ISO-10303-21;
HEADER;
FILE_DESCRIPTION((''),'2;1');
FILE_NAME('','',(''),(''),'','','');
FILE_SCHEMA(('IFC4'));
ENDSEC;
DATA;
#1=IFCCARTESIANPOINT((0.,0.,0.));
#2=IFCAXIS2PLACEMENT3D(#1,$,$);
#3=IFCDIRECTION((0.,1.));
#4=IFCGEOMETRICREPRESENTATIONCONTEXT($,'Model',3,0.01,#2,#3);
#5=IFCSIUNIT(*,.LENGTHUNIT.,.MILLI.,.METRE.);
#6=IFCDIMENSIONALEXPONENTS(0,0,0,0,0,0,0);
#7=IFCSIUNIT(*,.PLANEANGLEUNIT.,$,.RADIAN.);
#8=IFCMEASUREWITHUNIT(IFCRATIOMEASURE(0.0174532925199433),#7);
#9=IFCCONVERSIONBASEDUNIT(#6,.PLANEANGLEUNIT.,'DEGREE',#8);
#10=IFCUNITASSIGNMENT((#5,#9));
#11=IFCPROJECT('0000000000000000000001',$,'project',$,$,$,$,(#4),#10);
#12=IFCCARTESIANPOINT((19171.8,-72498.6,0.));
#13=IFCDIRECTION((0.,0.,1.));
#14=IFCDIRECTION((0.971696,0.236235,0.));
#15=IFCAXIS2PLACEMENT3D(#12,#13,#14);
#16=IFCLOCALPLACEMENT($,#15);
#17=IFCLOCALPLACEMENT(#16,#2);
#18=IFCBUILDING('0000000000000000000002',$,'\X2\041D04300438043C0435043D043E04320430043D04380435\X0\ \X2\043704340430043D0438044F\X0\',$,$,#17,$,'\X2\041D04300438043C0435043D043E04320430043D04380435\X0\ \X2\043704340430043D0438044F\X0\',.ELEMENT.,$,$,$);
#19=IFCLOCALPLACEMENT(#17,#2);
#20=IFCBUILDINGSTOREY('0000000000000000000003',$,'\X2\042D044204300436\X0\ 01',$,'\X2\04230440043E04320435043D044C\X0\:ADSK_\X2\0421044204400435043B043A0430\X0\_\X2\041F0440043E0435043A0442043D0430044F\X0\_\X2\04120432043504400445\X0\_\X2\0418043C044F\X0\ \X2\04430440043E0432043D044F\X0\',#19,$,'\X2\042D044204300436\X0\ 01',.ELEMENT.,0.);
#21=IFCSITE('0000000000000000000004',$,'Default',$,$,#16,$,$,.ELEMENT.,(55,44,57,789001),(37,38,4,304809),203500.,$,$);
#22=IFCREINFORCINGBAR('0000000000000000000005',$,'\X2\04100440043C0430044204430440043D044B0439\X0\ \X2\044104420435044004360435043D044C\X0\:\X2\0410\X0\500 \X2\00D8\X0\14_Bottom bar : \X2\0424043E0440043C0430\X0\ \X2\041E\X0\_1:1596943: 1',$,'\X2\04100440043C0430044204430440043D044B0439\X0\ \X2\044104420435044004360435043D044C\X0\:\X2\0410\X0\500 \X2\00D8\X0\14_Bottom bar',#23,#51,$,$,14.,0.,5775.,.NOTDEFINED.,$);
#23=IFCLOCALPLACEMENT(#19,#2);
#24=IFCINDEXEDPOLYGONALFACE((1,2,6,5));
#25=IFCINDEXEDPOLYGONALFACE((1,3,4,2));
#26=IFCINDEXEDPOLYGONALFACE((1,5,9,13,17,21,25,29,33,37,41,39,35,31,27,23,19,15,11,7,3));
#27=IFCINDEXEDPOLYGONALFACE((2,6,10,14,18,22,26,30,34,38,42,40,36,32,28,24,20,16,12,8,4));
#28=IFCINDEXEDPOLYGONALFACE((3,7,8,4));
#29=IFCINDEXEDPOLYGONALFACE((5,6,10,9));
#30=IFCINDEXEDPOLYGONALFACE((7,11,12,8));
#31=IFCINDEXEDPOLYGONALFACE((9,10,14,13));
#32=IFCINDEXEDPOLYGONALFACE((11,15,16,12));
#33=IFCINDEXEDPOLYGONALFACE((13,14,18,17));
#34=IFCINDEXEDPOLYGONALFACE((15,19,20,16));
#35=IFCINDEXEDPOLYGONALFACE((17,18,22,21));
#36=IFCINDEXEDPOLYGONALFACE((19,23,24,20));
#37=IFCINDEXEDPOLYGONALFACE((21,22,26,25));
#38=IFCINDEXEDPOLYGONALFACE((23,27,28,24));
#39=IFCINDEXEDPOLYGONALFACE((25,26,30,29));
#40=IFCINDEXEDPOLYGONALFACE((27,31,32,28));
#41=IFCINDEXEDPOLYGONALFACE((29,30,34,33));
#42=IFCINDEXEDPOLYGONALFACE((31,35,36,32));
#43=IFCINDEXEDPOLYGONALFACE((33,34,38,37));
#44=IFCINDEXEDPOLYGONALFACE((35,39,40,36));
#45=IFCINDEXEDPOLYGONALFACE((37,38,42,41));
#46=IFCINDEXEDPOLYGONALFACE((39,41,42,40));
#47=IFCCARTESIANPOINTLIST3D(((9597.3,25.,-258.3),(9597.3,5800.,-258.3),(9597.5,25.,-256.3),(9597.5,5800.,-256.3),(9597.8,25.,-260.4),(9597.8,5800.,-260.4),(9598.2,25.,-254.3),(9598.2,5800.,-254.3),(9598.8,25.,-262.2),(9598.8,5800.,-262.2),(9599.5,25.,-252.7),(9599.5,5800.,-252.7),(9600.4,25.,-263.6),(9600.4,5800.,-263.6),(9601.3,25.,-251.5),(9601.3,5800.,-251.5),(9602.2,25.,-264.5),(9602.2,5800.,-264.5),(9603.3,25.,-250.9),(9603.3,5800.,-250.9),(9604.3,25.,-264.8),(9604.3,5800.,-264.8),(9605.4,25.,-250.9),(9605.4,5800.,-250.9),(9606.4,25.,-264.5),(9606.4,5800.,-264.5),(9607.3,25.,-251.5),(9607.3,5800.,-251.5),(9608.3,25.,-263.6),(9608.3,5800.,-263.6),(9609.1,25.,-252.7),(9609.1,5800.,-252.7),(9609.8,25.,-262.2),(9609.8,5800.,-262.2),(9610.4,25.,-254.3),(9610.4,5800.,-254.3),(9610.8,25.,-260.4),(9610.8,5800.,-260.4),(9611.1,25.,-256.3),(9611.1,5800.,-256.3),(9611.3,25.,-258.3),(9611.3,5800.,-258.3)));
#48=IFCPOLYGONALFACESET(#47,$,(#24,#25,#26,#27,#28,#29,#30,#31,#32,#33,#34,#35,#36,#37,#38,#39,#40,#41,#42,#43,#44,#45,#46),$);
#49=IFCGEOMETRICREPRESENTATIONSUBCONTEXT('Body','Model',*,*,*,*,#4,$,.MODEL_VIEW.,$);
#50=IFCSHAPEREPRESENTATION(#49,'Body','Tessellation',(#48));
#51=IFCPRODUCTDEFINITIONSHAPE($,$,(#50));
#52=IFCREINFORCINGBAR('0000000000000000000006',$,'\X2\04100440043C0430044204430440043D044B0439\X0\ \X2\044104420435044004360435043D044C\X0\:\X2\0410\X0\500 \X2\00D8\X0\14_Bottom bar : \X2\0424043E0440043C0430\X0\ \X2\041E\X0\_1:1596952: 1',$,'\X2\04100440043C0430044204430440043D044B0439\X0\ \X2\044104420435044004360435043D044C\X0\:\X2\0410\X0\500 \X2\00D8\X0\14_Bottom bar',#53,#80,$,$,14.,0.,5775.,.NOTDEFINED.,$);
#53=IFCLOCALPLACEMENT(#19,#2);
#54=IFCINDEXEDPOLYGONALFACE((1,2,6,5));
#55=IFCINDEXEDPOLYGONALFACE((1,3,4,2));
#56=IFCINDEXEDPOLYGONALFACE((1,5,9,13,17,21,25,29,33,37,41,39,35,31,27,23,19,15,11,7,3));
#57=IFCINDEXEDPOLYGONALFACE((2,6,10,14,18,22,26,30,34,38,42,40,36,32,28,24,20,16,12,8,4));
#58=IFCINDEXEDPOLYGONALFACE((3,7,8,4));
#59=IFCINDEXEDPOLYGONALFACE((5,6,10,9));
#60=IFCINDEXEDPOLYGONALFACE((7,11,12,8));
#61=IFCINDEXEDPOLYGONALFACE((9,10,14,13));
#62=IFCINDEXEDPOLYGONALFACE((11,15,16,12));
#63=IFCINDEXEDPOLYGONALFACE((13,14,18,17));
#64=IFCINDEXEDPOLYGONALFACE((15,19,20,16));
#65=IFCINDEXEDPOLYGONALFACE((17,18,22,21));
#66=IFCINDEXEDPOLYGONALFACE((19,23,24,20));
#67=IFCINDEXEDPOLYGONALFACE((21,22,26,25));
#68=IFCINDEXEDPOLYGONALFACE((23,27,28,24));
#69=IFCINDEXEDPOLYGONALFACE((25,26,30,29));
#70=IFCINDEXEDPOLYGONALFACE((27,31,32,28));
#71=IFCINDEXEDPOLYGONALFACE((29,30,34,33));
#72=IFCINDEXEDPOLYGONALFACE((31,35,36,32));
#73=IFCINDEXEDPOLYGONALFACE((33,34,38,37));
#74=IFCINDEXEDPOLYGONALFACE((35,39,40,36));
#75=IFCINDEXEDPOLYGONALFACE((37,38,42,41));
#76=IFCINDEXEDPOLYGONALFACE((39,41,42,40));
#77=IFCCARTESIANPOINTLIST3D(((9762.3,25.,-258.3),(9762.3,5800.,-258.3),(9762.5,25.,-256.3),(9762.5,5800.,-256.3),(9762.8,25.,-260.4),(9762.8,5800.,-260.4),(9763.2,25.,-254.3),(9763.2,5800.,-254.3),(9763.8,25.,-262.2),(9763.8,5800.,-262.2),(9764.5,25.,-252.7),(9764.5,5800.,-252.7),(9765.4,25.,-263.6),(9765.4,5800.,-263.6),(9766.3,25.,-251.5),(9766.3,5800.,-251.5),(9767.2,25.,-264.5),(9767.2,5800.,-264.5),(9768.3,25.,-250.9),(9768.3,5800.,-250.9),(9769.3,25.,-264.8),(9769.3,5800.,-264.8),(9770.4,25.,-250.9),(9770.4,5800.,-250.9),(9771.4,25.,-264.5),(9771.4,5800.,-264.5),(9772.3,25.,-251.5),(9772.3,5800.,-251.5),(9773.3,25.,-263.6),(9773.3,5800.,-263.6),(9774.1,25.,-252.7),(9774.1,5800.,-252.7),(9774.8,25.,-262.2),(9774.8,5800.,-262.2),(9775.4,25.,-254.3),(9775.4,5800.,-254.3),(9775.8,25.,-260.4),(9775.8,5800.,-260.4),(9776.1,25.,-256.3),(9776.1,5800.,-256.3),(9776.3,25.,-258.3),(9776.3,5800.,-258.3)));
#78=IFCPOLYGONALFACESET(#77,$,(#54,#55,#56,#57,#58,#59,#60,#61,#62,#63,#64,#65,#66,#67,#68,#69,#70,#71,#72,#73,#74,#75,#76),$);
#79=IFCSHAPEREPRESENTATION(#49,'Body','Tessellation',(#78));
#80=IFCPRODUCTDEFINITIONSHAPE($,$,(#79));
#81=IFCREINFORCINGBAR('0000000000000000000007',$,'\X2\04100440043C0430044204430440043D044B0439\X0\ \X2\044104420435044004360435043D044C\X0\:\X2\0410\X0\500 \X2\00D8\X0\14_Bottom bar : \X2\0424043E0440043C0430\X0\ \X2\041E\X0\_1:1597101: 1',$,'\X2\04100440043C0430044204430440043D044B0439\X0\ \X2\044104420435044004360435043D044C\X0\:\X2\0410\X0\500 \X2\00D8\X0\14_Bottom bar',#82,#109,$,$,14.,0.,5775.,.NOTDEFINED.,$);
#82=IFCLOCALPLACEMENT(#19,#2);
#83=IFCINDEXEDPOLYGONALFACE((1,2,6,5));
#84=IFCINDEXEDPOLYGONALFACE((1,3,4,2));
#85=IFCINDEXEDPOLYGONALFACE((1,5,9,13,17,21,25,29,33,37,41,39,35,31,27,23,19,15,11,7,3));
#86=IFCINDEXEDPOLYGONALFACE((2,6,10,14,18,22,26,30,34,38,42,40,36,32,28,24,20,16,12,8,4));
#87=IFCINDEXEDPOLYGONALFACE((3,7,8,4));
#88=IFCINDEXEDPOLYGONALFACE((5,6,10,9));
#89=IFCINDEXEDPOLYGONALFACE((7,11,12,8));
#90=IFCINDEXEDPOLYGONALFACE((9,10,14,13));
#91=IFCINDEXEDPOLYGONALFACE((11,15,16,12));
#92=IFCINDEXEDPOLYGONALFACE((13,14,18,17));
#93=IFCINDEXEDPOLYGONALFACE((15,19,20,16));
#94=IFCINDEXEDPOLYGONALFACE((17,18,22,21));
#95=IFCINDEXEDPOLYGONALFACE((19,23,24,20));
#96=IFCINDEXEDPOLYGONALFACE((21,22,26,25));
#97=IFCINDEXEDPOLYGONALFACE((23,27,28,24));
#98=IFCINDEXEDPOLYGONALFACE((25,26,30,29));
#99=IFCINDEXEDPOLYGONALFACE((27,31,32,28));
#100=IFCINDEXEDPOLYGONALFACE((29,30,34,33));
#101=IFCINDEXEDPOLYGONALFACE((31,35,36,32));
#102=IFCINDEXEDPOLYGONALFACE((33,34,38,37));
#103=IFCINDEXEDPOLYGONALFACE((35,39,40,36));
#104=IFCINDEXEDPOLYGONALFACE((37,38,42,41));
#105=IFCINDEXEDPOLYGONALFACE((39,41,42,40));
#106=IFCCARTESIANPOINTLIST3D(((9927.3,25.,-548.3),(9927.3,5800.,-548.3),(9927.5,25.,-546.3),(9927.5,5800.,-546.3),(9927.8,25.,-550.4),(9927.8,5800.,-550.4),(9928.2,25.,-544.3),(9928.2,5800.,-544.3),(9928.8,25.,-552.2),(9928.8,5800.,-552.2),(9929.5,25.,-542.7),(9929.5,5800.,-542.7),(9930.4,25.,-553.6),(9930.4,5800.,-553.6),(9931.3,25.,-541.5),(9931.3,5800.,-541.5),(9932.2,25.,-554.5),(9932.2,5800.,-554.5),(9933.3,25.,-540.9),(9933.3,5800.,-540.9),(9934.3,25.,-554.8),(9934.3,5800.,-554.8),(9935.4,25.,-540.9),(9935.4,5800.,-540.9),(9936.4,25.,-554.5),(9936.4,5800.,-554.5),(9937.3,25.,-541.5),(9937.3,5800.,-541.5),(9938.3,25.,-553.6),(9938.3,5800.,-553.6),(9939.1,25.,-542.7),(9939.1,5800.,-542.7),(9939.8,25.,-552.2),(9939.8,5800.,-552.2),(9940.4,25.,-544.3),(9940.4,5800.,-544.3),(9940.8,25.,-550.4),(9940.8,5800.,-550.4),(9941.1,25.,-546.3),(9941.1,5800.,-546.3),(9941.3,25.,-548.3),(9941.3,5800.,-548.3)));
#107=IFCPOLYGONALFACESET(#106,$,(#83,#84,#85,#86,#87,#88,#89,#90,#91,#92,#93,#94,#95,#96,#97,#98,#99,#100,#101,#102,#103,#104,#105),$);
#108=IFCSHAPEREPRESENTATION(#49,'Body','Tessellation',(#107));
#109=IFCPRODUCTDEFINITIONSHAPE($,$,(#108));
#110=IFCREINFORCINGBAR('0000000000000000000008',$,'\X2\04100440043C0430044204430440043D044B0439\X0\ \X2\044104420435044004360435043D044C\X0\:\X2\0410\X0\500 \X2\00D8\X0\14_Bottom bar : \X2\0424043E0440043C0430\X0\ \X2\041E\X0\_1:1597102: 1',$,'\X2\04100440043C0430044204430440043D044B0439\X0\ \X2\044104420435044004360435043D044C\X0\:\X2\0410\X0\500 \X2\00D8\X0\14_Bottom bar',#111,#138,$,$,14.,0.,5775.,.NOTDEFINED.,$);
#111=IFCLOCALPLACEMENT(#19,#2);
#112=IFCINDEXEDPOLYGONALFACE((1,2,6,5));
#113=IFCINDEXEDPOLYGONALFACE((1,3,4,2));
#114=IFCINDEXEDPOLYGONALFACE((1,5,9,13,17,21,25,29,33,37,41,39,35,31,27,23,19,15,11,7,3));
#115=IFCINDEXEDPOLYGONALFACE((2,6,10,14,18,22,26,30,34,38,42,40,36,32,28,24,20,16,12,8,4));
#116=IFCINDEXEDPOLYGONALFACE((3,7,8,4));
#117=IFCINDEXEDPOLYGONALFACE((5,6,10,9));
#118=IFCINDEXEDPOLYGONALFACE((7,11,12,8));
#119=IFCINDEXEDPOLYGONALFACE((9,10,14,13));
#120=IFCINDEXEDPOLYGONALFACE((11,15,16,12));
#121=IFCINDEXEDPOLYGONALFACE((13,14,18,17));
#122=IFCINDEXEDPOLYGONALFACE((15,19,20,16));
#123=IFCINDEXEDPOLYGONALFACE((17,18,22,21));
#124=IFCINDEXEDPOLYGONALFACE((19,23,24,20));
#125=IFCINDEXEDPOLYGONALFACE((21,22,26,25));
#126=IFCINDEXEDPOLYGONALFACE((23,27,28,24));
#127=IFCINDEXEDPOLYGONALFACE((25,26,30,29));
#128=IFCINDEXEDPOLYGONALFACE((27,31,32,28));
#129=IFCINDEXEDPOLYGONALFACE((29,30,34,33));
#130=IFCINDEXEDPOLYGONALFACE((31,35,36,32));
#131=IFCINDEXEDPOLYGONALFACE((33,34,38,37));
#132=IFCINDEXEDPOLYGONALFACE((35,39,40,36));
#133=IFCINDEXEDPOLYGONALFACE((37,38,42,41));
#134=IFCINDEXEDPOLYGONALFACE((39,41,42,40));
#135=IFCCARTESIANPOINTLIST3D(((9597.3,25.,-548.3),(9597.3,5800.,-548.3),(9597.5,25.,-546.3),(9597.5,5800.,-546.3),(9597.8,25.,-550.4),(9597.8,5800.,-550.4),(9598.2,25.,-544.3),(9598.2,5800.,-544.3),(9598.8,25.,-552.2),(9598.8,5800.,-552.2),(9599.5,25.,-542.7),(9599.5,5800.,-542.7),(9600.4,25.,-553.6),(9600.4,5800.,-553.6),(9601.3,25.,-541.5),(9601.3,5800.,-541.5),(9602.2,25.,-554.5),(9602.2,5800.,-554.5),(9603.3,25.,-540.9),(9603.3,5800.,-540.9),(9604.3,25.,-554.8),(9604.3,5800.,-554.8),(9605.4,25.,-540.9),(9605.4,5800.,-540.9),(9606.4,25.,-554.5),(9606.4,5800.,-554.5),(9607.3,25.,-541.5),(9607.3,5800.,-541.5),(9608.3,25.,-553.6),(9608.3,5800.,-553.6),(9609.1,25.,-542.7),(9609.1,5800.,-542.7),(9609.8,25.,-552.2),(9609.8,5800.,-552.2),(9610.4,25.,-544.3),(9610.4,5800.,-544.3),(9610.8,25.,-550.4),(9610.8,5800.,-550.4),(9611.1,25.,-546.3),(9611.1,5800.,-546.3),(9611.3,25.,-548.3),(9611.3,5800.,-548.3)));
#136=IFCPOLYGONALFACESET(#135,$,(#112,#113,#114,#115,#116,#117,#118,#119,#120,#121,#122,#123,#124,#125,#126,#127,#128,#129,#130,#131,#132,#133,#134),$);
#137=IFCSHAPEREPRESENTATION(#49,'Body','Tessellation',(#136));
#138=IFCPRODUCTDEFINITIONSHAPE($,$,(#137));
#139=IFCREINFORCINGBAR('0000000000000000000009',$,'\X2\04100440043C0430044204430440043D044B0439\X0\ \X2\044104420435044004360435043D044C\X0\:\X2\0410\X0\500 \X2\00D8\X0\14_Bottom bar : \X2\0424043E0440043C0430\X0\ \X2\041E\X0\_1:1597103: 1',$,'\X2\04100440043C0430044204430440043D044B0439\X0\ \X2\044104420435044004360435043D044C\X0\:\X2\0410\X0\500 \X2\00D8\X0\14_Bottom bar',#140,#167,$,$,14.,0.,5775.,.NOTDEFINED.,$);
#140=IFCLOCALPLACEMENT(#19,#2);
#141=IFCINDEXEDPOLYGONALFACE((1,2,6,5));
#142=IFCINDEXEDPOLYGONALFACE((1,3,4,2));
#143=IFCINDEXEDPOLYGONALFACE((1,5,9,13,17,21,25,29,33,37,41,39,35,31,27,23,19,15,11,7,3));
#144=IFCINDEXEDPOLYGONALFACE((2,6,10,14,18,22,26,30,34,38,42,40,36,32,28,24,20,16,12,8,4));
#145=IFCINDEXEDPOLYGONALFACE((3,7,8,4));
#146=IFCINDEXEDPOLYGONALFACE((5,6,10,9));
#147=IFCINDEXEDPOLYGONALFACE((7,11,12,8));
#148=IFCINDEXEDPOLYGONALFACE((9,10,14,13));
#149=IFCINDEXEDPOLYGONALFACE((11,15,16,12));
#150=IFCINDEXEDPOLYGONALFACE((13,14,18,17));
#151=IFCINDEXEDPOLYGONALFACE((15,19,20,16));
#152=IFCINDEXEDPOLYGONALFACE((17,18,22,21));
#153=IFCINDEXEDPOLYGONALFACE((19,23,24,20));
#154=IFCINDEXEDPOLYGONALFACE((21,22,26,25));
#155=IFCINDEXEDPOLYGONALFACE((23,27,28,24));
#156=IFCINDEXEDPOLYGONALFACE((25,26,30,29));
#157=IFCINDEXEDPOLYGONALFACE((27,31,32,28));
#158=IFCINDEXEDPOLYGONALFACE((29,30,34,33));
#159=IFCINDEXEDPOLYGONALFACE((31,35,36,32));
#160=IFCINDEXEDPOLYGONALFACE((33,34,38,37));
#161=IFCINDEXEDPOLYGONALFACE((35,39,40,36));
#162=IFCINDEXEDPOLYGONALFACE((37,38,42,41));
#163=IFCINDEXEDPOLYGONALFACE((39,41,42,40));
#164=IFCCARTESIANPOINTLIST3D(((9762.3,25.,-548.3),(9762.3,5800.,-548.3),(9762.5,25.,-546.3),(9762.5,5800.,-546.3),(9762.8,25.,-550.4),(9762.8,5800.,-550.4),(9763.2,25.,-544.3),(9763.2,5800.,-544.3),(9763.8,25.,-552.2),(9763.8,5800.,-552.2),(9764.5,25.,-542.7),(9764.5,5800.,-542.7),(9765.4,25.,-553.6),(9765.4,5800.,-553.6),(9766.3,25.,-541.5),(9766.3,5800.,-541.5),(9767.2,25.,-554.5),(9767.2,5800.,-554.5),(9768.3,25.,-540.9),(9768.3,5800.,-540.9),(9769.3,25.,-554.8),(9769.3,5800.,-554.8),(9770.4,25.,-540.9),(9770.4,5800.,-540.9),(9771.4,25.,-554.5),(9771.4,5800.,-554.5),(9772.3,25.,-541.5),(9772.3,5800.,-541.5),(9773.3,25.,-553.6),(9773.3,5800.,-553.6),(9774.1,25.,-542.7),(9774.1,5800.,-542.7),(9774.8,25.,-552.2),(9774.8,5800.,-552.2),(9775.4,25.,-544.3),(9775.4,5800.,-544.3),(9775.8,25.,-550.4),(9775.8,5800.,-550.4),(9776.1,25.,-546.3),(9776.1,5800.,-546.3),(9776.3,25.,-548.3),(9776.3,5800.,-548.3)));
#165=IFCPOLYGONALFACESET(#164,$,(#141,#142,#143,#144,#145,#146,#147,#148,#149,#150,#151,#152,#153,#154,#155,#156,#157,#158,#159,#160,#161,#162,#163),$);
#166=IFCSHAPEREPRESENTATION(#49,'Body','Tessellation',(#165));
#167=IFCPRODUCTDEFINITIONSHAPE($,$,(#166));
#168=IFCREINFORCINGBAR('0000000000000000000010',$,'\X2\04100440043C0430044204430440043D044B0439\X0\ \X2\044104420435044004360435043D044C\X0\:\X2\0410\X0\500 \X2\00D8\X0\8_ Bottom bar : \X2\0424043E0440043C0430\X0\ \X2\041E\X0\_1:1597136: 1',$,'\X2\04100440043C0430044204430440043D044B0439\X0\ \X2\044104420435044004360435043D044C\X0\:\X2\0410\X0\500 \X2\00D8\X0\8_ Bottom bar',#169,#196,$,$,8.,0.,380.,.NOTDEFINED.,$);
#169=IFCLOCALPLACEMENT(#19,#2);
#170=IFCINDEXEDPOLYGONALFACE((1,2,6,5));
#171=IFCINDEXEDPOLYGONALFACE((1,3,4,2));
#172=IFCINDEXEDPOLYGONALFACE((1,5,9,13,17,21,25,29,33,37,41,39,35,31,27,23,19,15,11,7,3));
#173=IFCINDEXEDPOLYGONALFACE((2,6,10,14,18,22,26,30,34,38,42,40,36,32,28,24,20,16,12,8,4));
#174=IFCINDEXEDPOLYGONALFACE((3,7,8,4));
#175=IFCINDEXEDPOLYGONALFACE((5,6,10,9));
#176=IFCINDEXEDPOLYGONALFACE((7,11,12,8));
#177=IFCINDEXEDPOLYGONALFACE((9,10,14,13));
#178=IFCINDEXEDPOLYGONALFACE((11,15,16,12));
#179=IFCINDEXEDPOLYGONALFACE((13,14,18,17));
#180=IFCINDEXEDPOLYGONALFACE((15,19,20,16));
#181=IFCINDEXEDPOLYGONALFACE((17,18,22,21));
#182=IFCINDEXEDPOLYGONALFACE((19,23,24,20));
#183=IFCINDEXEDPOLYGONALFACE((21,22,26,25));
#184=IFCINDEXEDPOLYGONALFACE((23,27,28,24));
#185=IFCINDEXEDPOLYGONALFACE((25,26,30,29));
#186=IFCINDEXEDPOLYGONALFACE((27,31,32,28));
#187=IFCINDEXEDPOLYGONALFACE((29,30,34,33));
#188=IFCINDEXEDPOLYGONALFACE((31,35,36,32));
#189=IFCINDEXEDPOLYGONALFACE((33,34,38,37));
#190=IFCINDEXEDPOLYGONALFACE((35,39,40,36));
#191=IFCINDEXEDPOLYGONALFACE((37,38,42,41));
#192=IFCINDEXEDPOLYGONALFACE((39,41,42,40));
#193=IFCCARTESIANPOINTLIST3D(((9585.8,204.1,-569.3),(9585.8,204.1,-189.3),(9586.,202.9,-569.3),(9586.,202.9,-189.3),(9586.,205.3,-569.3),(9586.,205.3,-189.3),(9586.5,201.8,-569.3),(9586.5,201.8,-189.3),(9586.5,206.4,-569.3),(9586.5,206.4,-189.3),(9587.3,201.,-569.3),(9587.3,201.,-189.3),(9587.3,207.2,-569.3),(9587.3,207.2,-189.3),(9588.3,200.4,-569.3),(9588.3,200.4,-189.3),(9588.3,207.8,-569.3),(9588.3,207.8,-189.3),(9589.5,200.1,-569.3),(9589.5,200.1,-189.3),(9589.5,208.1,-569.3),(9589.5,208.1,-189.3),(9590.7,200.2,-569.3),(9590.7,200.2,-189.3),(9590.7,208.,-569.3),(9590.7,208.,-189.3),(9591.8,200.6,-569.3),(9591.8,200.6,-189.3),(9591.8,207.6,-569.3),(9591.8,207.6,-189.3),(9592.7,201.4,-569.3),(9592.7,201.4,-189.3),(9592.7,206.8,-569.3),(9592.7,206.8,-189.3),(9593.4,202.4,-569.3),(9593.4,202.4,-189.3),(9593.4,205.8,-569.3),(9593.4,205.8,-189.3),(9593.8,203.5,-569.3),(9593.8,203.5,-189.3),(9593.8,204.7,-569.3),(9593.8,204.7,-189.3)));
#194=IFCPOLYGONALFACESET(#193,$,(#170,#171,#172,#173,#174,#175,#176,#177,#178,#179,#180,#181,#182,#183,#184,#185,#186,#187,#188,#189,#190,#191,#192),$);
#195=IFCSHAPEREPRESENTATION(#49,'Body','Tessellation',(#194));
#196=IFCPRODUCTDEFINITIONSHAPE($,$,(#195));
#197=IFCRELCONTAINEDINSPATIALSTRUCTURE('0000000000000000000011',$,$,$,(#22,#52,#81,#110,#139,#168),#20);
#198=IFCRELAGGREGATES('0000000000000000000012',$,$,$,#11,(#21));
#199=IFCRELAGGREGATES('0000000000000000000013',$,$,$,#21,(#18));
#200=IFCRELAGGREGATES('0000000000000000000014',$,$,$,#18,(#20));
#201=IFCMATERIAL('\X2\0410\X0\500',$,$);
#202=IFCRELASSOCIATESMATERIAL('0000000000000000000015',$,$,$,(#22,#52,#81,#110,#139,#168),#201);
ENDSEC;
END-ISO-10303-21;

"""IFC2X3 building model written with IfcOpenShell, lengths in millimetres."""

from ifc_helpers import new_model, entity, si_unit, converted_unit, direction, frame, origin, place, context, subcontext, project, spatial, material, element, save


model = new_model("IFC2X3")

# Units and contexts
model_context = context("Model", 3, precision=0.01, world=origin(), true_north=direction((0.0, 1.0)))
body_context = subcontext(model_context, "Body", "Model", "MODEL_VIEW")
ifc_project = project(units=[si_unit("LENGTHUNIT", "METRE", prefix="MILLI"), converted_unit("PLANEANGLEUNIT", "DEGREE", entity("IfcRatioMeasure", 0.0174532925199433), si_unit("PLANEANGLEUNIT", "RADIAN"), dimensions=[0, 0, 0, 0, 0, 0, 0])], contexts=[model_context])

# Site, building, storey
site_placement = place(None, frame((19171.8, -72498.6, 0.0), z_axis=(0.0, 0.0, 1.0), x_axis=(0.971696, 0.236235, 0.0)))
site = spatial("IfcSite", under=ifc_project, at=site_placement, Name="Default", CompositionType="ELEMENT", RefLatitude=(55, 44, 57, 789001), RefLongitude=(37, 38, 4, 304809), RefElevation=203500.0)
building_placement = place(site_placement, origin())
building = spatial("IfcBuilding", under=site, at=building_placement, Name="Наименование здания", LongName="Наименование здания", CompositionType="ELEMENT")
storey_placement = place(building_placement, origin())
storey = spatial("IfcBuildingStorey", under=building, at=storey_placement, Name="Этаж 01", ObjectType="Уровень:ADSK_Стрелка_Проектная_Вверх_Имя уровня", LongName="Этаж 01", CompositionType="ELEMENT", Elevation=0.0)

# Reinforcing bars
ifc_material = material(Name="А500")
placement = place(storey_placement, origin())
element("IfcReinforcingBar", 1, at=placement, inside=storey, material=ifc_material, Name="Арматурный стержень:А500 Ø14_Bottom bar : Форма О_1:1596943: 1", ObjectType="Арматурный стержень:А500 Ø14_Bottom bar", BarLength=5775.0, BarRole="NOTDEFINED", CrossSectionArea=0.0, NominalDiameter=14.0, context=body_context, shape_type="AdvancedSweptSolid", body=[
    entity("IfcSweptDiskSolid", entity("IfcCompositeCurve", [entity("IfcCompositeCurveSegment", "CONTINUOUS", True, entity("IfcPolyline", [entity("IfcCartesianPoint", [9604.3, 5800.0, -257.8]), entity("IfcCartesianPoint", [9604.3, 25.0, -257.8])]))], False), 7.0, None, 0.0, 1.0),
])
element("IfcReinforcingBar", 2, at=placement, inside=storey, material=ifc_material, Name="Арматурный стержень:А500 Ø14_Bottom bar : Форма О_1:1596952: 1", ObjectType="Арматурный стержень:А500 Ø14_Bottom bar", BarLength=5775.0, BarRole="NOTDEFINED", CrossSectionArea=0.0, NominalDiameter=14.0, context=body_context, shape_type="AdvancedSweptSolid", body=[
    entity("IfcSweptDiskSolid", entity("IfcCompositeCurve", [entity("IfcCompositeCurveSegment", "CONTINUOUS", True, entity("IfcPolyline", [entity("IfcCartesianPoint", [9769.3, 5800.0, -257.8]), entity("IfcCartesianPoint", [9769.3, 25.0, -257.8])]))], False), 7.0, None, 0.0, 1.0),
])
element("IfcReinforcingBar", 3, at=placement, inside=storey, material=ifc_material, Name="Арматурный стержень:А500 Ø14_Bottom bar : Форма О_1:1597101: 1", ObjectType="Арматурный стержень:А500 Ø14_Bottom bar", BarLength=5775.0, BarRole="NOTDEFINED", CrossSectionArea=0.0, NominalDiameter=14.0, context=body_context, shape_type="AdvancedSweptSolid", body=[
    entity("IfcSweptDiskSolid", entity("IfcCompositeCurve", [entity("IfcCompositeCurveSegment", "CONTINUOUS", True, entity("IfcPolyline", [entity("IfcCartesianPoint", [9934.3, 5800.0, -547.8]), entity("IfcCartesianPoint", [9934.3, 25.0, -547.8])]))], False), 7.0, None, 0.0, 1.0),
])
element("IfcReinforcingBar", 4, at=placement, inside=storey, material=ifc_material, Name="Арматурный стержень:А500 Ø14_Bottom bar : Форма О_1:1597102: 1", ObjectType="Арматурный стержень:А500 Ø14_Bottom bar", BarLength=5775.0, BarRole="NOTDEFINED", CrossSectionArea=0.0, NominalDiameter=14.0, context=body_context, shape_type="AdvancedSweptSolid", body=[
    entity("IfcSweptDiskSolid", entity("IfcCompositeCurve", [entity("IfcCompositeCurveSegment", "CONTINUOUS", True, entity("IfcPolyline", [entity("IfcCartesianPoint", [9604.3, 5800.0, -547.8]), entity("IfcCartesianPoint", [9604.3, 25.0, -547.8])]))], False), 7.0, None, 0.0, 1.0),
])
element("IfcReinforcingBar", 5, at=placement, inside=storey, material=ifc_material, Name="Арматурный стержень:А500 Ø14_Bottom bar : Форма О_1:1597103: 1", ObjectType="Арматурный стержень:А500 Ø14_Bottom bar", BarLength=5775.0, BarRole="NOTDEFINED", CrossSectionArea=0.0, NominalDiameter=14.0, context=body_context, shape_type="AdvancedSweptSolid", body=[
    entity("IfcSweptDiskSolid", entity("IfcCompositeCurve", [entity("IfcCompositeCurveSegment", "CONTINUOUS", True, entity("IfcPolyline", [entity("IfcCartesianPoint", [9769.3, 5800.0, -547.8]), entity("IfcCartesianPoint", [9769.3, 25.0, -547.8])]))], False), 7.0, None, 0.0, 1.0),
])
element("IfcReinforcingBar", 6, at=placement, inside=storey, material=ifc_material, Name="Арматурный стержень:А500 Ø8_ Bottom bar : Форма О_1:1597136: 1", ObjectType="Арматурный стержень:А500 Ø8_ Bottom bar", BarLength=380.0, BarRole="NOTDEFINED", CrossSectionArea=0.0, NominalDiameter=8.0, context=body_context, shape_type="AdvancedSweptSolid", body=[
    entity("IfcSweptDiskSolid", entity("IfcCompositeCurve", [entity("IfcCompositeCurveSegment", "CONTINUOUS", True, entity("IfcPolyline", [entity("IfcCartesianPoint", [9589.8, 204.1, -189.3]), entity("IfcCartesianPoint", [9589.8, 204.1, -569.3])]))], False), 4.0, None, 0.0, 1.0),
])

save(model, "model.ifc")
